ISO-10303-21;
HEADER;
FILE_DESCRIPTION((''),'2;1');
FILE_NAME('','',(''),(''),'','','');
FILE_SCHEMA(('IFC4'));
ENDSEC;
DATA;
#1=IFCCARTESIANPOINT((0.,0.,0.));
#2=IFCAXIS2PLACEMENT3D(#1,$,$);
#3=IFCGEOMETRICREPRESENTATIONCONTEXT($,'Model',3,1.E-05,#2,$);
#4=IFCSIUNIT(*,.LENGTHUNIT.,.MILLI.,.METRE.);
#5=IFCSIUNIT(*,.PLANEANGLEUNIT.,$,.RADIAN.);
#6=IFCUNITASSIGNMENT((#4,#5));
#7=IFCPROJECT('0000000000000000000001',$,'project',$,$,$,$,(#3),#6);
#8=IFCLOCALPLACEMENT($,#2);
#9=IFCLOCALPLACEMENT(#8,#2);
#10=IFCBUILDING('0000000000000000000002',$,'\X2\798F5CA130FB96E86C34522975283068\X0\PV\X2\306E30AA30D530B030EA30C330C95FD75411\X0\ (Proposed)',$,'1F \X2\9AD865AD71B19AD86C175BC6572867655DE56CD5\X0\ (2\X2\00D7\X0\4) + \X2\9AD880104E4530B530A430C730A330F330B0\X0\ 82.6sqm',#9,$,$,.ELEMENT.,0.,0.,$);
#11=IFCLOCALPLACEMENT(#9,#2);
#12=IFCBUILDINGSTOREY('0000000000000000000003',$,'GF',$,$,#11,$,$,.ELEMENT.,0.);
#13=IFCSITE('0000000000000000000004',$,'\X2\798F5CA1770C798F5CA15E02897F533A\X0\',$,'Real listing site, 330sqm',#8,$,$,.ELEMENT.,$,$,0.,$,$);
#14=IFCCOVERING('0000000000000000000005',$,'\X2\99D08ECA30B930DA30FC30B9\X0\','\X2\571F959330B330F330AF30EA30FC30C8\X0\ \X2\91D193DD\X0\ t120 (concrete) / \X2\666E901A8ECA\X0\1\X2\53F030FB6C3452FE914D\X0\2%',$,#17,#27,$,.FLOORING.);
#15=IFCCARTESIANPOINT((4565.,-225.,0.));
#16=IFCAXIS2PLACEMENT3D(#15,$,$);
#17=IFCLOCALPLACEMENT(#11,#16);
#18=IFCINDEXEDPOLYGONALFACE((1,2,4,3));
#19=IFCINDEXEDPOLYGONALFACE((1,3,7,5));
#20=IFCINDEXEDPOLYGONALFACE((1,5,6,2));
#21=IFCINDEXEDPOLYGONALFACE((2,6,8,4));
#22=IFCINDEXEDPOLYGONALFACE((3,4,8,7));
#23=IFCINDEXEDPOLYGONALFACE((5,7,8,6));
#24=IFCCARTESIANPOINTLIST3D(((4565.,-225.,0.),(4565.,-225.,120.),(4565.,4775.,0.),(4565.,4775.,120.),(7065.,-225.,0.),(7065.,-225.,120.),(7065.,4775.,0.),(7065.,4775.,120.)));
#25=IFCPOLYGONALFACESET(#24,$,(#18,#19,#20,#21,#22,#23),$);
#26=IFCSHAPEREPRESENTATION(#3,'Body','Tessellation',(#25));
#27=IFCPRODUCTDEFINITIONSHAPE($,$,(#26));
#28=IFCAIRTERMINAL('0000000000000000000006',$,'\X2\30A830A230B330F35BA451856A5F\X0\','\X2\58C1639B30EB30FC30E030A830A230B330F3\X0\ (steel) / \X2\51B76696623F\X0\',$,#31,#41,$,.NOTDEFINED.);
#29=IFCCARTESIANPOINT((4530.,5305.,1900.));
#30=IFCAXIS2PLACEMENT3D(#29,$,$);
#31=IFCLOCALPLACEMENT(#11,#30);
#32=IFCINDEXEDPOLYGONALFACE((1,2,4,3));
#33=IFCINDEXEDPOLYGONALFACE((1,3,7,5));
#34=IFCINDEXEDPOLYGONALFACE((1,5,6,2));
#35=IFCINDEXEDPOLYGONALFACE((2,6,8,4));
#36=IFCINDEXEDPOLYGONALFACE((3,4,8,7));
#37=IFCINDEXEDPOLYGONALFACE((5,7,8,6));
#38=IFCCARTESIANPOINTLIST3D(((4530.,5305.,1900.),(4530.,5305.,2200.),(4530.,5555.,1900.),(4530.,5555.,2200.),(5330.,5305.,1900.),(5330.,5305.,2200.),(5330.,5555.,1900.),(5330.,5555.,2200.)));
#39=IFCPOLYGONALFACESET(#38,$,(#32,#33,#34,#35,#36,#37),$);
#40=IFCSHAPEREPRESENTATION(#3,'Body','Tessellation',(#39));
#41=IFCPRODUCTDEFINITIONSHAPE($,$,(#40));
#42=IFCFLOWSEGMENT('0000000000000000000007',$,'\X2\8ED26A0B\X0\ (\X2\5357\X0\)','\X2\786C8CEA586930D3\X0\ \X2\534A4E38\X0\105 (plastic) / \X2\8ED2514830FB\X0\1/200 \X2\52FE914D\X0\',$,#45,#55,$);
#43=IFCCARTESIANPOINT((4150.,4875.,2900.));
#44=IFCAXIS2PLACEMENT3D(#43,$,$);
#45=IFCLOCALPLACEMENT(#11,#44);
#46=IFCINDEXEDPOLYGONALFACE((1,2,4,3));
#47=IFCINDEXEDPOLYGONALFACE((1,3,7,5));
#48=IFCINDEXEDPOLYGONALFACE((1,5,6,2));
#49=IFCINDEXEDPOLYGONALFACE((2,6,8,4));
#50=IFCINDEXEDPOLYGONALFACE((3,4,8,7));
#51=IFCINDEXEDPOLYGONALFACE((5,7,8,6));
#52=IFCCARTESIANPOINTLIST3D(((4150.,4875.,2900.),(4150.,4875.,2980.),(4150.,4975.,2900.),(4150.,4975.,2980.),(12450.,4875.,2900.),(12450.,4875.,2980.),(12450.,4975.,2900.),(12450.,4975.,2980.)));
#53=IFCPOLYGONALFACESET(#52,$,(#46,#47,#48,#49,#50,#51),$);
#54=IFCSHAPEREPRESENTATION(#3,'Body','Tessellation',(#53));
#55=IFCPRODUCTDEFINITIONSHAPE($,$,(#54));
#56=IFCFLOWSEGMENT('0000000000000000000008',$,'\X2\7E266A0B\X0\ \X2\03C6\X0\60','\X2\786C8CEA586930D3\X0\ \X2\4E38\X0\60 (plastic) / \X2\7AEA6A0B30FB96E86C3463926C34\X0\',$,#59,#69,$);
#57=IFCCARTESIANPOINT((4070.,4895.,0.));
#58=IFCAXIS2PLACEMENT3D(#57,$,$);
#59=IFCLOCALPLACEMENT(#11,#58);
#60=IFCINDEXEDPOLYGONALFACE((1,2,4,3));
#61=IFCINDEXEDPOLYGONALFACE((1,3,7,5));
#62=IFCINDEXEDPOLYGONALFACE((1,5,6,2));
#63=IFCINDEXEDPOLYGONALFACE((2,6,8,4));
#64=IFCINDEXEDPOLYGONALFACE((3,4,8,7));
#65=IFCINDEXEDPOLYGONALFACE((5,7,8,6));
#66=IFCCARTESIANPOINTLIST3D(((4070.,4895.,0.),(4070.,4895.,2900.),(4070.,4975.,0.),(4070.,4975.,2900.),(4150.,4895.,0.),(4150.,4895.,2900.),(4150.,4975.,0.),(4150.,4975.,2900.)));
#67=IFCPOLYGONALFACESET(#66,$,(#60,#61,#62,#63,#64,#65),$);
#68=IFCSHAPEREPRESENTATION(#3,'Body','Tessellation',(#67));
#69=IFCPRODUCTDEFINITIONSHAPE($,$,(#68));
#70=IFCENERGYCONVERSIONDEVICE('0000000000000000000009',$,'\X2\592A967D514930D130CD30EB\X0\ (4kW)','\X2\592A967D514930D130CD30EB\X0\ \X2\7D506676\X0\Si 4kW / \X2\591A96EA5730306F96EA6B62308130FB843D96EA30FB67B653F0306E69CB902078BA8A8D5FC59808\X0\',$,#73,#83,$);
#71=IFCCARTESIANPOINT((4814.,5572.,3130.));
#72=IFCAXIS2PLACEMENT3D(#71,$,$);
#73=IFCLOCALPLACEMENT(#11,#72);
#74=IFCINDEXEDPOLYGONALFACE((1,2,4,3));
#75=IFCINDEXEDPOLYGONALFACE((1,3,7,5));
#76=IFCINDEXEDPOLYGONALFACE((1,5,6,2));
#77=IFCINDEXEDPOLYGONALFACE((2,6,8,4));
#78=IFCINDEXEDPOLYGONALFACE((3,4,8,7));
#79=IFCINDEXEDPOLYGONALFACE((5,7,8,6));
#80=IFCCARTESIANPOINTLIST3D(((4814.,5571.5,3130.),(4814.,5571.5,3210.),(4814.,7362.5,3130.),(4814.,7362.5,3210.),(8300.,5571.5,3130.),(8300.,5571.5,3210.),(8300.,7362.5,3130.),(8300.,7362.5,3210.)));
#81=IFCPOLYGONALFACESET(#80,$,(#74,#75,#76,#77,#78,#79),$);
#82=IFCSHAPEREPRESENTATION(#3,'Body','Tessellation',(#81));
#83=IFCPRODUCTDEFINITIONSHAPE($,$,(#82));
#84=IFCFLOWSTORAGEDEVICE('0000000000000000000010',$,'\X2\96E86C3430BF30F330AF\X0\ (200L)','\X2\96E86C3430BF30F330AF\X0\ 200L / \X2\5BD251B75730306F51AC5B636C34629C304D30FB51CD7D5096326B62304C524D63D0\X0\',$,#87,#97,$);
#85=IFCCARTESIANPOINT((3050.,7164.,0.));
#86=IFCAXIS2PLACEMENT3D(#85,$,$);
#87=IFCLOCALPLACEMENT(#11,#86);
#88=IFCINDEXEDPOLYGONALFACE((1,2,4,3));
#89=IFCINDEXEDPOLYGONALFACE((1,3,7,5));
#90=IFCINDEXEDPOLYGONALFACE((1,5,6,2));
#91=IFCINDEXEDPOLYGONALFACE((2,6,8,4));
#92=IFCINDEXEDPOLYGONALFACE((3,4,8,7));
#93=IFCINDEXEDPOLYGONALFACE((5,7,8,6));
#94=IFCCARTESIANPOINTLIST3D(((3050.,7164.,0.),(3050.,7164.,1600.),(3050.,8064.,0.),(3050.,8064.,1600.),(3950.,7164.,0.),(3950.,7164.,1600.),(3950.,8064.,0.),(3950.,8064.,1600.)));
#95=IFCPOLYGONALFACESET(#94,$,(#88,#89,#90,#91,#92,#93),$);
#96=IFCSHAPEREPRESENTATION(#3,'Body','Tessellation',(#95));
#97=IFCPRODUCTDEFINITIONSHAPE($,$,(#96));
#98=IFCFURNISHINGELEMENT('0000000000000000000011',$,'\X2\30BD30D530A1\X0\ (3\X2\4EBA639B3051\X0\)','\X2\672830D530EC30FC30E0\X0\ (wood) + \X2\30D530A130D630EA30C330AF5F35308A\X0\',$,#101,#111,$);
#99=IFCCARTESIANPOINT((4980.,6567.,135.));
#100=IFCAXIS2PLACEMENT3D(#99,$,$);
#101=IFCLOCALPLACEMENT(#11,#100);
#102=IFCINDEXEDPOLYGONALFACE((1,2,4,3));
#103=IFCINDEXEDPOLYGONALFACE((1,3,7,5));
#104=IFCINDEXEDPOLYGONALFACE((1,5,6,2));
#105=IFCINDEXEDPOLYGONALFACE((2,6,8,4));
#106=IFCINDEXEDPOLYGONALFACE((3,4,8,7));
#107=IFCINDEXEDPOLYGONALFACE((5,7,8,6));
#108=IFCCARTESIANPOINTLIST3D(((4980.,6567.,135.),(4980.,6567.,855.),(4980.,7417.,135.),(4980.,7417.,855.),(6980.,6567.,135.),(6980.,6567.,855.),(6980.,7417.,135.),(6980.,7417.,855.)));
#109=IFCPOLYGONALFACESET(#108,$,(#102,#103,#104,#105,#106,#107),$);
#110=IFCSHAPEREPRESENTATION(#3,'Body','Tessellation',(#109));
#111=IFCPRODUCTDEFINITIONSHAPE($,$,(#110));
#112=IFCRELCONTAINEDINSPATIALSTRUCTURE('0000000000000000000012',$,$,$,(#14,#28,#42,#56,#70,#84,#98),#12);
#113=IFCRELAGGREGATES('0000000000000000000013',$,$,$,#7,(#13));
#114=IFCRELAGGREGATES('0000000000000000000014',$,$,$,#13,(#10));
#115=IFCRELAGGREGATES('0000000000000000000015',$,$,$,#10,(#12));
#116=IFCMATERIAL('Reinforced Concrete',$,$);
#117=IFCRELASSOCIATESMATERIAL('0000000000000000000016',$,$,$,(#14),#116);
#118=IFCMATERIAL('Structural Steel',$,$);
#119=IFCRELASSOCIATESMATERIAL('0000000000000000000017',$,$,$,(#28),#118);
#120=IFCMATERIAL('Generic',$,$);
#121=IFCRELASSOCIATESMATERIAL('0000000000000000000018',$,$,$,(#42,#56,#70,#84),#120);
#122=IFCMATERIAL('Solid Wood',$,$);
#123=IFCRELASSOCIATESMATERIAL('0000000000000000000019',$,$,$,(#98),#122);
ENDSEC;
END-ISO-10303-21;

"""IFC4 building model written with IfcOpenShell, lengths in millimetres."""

from ifc_helpers import new_model, si_unit, frame, frame_2d, origin, place, context, project, spatial, rectangle, extrude, material, element, save


model = new_model("IFC4")

# Units and contexts
model_context = context("Model", 3, precision=1e-05, world=origin())
ifc_project = project(units=[si_unit("LENGTHUNIT", "METRE", prefix="MILLI"), si_unit("PLANEANGLEUNIT", "RADIAN")], contexts=[model_context])

# Site, building, storey
site_placement = place(None, origin())
site = spatial("IfcSite", under=ifc_project, at=site_placement, Name="福岡県福岡市西区", ObjectType="Real listing site, 330sqm", CompositionType="ELEMENT", RefElevation=0.0)
building_placement = place(site_placement, origin())
building = spatial("IfcBuilding", under=site, at=building_placement, Name="福岡・雨水利用とPVのオフグリッド志向 (Proposed)", ObjectType="1F 高断熱高気密在来工法 (2×4) + 高耐久サイディング 82.6sqm", CompositionType="ELEMENT", ElevationOfRefHeight=0.0, ElevationOfTerrain=0.0)
storey_placement = place(building_placement, origin())
storey = spatial("IfcBuildingStorey", under=building, at=storey_placement, Name="GF", CompositionType="ELEMENT", Elevation=0.0)

# Shared definitions
ifc_material_1 = material(Name="Solid Wood")

# Shared definitions
ifc_material_2 = material(Name="Reinforced Concrete")

# Shared definitions
ifc_material_3 = material(Name="Structural Steel")

# Covering
ifc_material_4 = material(Name="Generic")
covering_1_placement = place(storey_placement, frame((4565.0, -225.0, 0.0)))
element("IfcCovering", 1, at=covering_1_placement, inside=storey, material=ifc_material_2, Name="駐車スペース", Description="土間コンクリート 金鏝 t120 (concrete) / 普通車1台・水勾配2%", PredefinedType="FLOORING", context=model_context, shape_type="SweptSolid", body=[
    extrude(rectangle(XDim=2500.0, YDim=5000.0, at=frame_2d((1250.0, 2500.0))), frame((4565.0, -225.0, 0.0)), (0.0, 0.0, 1.0), 120.0),
])

# Air terminal
air_terminal_placement = place(storey_placement, frame((4530.0, 5305.0, 1900.0)))
element("IfcAirTerminal", 2, at=air_terminal_placement, inside=storey, material=ifc_material_3, Name="エアコン室内機", Description="壁掛ルームエアコン (steel) / 冷暖房", PredefinedType="NOTDEFINED", context=model_context, shape_type="SweptSolid", body=[
    extrude(rectangle(XDim=800.0, YDim=250.0, at=frame_2d((400.0, 125.0))), frame((4530.0, 5305.0, 1900.0)), (0.0, 0.0, 1.0), 300.0),
])

# Flow segments
flow_segment_1_placement = place(storey_placement, frame((4150.0, 4875.0, 2900.0)))
element("IfcFlowSegment", 3, at=flow_segment_1_placement, inside=storey, material=ifc_material_4, Name="軒樋 (南)", Description="硬質塩ビ 半丸105 (plastic) / 軒先・1/200 勾配", context=model_context, shape_type="SweptSolid", body=[
    extrude(rectangle(XDim=8300.0, YDim=100.0, at=frame_2d((4150.0, 50.0))), frame((4150.0, 4875.0, 2900.0)), (0.0, 0.0, 1.0), 80.0),
])
flow_segment_2_placement = place(storey_placement, frame((4070.0, 4895.0, 0.0)))
element("IfcFlowSegment", 4, at=flow_segment_2_placement, inside=storey, material=ifc_material_4, Name="縦樋 φ60", Description="硬質塩ビ 丸60 (plastic) / 竪樋・雨水排水", context=model_context, shape_type="SweptSolid", body=[
    extrude(rectangle(XDim=80.0, YDim=80.0, at=frame_2d((40.0, 40.0))), frame((4070.0, 4895.0, 0.0)), (0.0, 0.0, 1.0), 2900.0),
])

# Energy conversion device
energy_conversion_device_placement = place(storey_placement, frame((4814.0, 5572.0, 3130.0)))
element("IfcEnergyConversionDevice", 5, at=energy_conversion_device_placement, inside=storey, material=ifc_material_4, Name="太陽光パネル (4kW)", Description="太陽光パネル 結晶Si 4kW / 多雪地は雪止め・落雪・架台の構造確認必須", context=model_context, shape_type="SweptSolid", body=[
    extrude(rectangle(XDim=3486.0, YDim=1791.0, at=frame_2d((1743.0, 895.0))), frame((4814.0, 5572.0, 3130.0)), (0.0, 0.0, 1.0), 80.0),
])

# Flow storage device
flow_storage_device_placement = place(storey_placement, frame((3050.0, 7164.0, 0.0)))
element("IfcFlowStorageDevice", 6, at=flow_storage_device_placement, inside=storey, material=ifc_material_4, Name="雨水タンク (200L)", Description="雨水タンク 200L / 寒冷地は冬季水抜き・凍結防止が前提", context=model_context, shape_type="SweptSolid", body=[
    extrude(rectangle(XDim=900.0, YDim=900.0, at=frame_2d((450.0, 450.0))), frame((3050.0, 7164.0, 0.0)), (0.0, 0.0, 1.0), 1600.0),
])

# Furnishing element
furnishing_placement = place(storey_placement, frame((4980.0, 6567.0, 135.0)))
element("IfcFurnishingElement", 7, at=furnishing_placement, inside=storey, material=ifc_material_1, Name="ソファ (3人掛け)", Description="木フレーム (wood) + ファブリック張り", context=model_context, shape_type="SweptSolid", body=[
    extrude(rectangle(XDim=2000.0, YDim=850.0, at=frame_2d((1000.0, 425.0))), frame((4980.0, 6567.0, 135.0)), (0.0, 0.0, 1.0), 720.0),
])

save(model, "model.ifc")
